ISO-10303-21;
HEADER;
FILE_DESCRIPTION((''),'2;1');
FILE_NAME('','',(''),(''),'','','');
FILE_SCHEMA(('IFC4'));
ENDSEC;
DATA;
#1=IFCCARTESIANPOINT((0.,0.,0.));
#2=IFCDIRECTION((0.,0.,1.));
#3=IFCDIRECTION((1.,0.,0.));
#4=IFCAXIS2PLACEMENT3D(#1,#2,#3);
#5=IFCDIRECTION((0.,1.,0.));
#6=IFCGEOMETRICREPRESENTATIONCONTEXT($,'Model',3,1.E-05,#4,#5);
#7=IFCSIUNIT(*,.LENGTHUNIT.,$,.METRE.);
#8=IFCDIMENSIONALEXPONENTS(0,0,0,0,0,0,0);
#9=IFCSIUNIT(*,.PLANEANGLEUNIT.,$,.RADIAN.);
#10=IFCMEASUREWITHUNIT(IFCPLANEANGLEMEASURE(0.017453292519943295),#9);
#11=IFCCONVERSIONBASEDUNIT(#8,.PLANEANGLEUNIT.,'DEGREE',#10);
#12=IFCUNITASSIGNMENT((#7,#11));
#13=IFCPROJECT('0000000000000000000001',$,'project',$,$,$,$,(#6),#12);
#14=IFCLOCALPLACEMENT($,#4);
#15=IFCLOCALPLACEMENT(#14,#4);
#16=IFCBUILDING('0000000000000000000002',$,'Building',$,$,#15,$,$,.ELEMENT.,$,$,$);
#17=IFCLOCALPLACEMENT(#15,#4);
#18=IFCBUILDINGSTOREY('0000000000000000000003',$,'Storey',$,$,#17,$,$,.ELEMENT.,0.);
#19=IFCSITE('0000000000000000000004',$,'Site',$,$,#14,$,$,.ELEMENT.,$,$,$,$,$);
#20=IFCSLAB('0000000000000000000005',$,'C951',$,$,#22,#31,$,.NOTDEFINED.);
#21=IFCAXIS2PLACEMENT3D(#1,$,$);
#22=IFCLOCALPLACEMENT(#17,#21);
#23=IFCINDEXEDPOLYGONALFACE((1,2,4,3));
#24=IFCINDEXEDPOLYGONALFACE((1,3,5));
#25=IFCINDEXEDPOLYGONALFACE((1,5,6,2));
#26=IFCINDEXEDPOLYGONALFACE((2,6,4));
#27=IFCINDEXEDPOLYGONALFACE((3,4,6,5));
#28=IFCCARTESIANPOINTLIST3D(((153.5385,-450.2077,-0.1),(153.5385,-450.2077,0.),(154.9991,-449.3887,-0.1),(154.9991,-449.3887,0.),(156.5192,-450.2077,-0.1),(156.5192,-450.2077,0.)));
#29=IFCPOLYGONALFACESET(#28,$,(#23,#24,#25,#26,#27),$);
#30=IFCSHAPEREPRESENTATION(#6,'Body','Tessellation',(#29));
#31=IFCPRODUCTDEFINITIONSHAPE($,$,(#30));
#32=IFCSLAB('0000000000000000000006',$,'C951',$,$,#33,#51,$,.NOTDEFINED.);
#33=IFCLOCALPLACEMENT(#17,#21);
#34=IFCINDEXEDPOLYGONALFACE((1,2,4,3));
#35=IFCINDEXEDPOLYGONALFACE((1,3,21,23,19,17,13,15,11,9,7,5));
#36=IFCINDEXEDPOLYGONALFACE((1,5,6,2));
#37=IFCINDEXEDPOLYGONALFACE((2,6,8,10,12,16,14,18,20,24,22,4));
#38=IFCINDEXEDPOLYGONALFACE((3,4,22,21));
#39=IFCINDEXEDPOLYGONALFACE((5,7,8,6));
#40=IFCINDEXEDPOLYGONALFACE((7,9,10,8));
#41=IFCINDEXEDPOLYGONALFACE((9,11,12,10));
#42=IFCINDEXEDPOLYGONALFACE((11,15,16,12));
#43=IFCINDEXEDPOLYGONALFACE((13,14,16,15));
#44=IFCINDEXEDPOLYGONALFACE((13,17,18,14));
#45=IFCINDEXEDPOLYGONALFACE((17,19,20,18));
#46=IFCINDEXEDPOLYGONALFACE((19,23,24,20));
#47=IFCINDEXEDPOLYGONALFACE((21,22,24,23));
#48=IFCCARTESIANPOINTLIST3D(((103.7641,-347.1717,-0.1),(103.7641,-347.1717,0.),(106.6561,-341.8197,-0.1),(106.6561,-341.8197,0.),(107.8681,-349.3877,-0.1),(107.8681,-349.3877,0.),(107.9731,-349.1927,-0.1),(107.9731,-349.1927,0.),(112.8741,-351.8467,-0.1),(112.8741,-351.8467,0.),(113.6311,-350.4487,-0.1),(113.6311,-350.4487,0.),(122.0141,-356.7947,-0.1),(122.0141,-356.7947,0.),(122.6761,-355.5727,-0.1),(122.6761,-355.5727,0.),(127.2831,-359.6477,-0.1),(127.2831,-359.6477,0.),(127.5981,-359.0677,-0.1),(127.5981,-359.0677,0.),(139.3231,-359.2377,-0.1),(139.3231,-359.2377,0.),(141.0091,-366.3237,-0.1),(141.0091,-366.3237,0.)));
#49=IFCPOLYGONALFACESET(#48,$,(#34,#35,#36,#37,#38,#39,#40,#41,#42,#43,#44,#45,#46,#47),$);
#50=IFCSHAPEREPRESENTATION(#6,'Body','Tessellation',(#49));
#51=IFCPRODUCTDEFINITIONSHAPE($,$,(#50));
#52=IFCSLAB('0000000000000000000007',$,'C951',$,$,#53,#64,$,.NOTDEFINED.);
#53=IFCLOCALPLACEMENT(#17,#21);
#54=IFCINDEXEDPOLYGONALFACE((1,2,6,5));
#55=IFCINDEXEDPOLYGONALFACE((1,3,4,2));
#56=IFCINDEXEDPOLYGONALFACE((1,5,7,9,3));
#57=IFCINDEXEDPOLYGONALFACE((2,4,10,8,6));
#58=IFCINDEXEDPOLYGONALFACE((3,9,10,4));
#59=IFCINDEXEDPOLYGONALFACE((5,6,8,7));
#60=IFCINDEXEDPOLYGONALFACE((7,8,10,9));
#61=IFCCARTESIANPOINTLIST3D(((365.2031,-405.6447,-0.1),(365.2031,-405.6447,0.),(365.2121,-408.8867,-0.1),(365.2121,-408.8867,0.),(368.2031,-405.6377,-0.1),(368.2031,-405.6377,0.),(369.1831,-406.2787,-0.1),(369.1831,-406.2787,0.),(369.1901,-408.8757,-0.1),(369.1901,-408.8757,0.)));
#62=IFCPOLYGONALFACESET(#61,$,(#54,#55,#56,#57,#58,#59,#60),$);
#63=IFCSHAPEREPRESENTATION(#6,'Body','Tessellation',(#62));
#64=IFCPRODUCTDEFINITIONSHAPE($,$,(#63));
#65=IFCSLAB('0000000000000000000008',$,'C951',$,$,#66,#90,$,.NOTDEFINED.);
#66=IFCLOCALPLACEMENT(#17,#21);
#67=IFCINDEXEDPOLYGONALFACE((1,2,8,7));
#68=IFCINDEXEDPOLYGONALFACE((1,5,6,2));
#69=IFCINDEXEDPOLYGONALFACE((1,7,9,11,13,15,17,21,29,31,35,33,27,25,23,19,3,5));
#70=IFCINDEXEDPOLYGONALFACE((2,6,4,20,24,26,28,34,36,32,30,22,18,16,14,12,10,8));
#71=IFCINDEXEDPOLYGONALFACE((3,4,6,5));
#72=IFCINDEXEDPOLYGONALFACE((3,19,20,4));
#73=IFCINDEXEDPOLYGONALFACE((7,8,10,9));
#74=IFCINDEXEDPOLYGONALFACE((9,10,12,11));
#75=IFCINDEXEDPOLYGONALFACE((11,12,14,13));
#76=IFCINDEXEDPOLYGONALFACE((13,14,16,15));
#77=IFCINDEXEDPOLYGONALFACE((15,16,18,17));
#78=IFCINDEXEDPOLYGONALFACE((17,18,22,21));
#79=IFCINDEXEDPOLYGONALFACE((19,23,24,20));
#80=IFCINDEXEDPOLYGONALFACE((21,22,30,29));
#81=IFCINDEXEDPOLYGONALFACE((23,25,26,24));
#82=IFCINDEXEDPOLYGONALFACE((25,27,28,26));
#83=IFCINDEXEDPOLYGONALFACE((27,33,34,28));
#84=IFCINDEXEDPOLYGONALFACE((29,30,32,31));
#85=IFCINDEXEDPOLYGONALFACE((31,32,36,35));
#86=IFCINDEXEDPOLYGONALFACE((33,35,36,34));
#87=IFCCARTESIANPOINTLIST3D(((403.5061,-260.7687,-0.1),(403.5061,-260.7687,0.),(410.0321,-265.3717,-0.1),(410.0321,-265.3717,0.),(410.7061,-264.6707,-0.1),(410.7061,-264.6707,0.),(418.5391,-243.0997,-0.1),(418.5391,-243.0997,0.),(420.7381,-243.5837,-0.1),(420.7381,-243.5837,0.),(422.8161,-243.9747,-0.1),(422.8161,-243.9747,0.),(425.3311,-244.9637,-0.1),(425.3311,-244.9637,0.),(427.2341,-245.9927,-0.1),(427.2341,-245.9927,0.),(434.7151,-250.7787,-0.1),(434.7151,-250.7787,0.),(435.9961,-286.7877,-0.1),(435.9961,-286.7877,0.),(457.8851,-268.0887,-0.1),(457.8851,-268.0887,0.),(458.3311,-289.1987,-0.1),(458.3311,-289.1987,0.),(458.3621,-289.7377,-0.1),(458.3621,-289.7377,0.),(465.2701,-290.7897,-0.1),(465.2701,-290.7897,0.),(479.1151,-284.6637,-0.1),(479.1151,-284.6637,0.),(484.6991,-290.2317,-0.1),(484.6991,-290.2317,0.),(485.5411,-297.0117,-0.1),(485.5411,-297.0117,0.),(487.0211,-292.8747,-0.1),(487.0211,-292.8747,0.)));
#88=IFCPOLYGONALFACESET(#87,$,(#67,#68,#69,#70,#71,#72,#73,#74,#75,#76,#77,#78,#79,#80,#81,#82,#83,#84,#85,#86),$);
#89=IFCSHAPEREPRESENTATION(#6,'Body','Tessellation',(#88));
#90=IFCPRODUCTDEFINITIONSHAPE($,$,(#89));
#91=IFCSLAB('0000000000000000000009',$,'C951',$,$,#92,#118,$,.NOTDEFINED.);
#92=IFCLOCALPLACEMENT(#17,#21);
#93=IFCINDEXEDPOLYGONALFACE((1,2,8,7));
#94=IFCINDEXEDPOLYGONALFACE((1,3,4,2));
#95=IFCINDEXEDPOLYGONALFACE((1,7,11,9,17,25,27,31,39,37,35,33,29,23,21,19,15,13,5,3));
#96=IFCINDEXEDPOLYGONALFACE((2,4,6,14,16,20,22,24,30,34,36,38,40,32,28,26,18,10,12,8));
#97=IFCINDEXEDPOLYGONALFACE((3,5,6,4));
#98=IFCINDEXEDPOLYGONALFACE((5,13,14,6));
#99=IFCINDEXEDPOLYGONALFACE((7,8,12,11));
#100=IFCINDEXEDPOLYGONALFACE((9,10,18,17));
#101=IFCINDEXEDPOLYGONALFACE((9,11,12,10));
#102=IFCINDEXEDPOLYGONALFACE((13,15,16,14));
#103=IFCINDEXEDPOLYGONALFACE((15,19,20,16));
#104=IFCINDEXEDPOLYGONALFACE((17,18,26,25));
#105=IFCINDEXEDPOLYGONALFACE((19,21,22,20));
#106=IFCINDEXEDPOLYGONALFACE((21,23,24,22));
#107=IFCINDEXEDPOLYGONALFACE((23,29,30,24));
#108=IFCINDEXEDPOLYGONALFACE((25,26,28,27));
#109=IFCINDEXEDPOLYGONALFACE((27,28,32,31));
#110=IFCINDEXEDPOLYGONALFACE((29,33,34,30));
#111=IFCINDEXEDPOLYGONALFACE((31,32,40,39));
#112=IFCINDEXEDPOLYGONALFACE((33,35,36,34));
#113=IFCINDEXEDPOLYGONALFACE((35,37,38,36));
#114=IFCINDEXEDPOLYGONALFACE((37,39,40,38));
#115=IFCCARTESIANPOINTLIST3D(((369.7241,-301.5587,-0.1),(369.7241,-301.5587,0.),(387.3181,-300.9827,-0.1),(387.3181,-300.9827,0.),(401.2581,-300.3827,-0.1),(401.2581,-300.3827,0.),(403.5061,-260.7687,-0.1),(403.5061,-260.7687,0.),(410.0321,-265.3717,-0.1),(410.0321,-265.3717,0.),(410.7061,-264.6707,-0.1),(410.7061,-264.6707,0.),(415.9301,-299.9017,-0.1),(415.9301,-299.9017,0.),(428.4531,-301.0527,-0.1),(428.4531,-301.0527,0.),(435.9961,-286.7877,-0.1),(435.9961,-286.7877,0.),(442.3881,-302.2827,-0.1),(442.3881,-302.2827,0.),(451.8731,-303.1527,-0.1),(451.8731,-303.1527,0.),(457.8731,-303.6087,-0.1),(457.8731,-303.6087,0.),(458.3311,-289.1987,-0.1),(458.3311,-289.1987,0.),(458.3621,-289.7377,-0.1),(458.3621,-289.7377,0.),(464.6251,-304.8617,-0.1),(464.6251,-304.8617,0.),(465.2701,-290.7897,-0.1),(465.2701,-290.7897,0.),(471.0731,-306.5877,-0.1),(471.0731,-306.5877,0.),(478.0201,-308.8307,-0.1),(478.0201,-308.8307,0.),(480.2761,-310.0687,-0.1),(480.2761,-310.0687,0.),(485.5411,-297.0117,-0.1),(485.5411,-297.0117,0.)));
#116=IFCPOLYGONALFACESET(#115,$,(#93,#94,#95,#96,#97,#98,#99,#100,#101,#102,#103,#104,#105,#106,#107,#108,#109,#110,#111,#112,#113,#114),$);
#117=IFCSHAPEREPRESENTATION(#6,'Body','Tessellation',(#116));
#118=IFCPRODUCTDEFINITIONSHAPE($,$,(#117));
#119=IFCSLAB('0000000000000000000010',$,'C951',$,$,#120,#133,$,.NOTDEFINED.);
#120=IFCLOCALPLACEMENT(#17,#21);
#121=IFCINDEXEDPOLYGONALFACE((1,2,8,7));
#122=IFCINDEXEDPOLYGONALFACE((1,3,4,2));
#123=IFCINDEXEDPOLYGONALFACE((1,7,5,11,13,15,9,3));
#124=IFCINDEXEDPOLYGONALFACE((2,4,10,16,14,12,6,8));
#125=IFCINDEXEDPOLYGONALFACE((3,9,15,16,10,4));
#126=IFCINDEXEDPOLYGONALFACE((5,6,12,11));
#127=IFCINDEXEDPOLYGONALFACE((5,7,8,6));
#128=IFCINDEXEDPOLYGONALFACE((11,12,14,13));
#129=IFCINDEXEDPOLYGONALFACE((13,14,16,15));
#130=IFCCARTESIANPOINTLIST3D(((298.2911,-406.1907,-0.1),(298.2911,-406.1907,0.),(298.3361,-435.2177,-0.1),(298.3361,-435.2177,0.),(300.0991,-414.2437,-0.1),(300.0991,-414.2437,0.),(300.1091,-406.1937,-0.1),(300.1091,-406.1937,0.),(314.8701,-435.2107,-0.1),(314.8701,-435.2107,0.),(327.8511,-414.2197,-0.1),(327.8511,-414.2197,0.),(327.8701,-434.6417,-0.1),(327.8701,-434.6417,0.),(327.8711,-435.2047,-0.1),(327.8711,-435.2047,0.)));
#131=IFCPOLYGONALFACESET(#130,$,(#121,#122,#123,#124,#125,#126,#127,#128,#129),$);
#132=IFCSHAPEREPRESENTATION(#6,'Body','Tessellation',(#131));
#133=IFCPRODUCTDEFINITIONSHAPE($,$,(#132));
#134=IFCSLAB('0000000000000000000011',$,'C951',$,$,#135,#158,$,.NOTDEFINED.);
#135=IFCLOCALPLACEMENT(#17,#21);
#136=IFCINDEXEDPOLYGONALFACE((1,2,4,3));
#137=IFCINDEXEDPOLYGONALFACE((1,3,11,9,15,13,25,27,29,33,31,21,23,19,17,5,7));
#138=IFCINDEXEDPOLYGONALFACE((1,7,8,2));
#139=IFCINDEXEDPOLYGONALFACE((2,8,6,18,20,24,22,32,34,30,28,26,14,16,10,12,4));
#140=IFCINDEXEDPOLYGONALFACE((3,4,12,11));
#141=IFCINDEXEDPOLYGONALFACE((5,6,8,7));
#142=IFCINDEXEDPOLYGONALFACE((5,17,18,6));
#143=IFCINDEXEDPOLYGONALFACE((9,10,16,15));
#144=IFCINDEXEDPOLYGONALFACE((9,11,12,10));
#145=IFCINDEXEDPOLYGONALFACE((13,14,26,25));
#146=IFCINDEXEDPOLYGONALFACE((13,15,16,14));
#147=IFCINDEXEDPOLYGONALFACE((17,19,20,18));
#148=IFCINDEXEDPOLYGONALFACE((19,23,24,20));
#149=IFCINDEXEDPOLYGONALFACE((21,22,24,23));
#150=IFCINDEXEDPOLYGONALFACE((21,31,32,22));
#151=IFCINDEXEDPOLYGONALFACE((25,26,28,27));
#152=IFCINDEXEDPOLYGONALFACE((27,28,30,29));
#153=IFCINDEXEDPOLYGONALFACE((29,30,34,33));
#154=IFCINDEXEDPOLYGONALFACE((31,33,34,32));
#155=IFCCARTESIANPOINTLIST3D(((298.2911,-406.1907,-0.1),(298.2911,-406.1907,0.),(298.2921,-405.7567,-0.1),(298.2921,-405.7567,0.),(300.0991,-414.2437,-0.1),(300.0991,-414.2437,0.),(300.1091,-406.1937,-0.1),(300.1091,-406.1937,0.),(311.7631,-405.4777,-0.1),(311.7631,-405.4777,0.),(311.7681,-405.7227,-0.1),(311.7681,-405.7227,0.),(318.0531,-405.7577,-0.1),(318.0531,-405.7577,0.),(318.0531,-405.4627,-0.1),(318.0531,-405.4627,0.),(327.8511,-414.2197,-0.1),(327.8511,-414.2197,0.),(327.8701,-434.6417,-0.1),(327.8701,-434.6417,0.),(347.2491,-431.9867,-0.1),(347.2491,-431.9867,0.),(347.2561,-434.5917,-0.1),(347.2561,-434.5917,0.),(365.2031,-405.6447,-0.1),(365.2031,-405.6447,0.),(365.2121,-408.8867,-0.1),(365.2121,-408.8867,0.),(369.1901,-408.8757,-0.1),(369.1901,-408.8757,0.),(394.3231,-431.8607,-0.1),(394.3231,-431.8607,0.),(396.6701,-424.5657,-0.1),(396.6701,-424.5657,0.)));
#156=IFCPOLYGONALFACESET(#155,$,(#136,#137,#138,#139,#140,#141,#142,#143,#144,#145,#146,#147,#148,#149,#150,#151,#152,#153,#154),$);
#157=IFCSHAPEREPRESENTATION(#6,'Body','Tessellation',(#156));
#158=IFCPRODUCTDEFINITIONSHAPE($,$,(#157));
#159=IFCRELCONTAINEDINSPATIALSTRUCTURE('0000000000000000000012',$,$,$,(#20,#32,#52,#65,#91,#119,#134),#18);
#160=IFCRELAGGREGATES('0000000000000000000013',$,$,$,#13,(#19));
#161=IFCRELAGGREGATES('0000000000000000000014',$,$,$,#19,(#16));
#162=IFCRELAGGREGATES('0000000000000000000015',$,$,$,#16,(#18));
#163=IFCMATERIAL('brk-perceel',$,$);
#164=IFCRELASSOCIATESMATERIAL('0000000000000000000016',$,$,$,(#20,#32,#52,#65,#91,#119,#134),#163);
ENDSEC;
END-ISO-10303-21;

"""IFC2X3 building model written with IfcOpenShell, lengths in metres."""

from ifc_helpers import new_model, entity, si_unit, converted_unit, direction, frame, origin_with_axes, place, context, project, spatial, polyline, outline, extrude, material, element, save


model = new_model("IFC2X3")

# Units and contexts
model_context = context("Model", 3, precision=1e-05, world=origin_with_axes(), true_north=direction((0.0, 1.0, 0.0)))
ifc_project = project(units=[si_unit("LENGTHUNIT", "METRE"), converted_unit("PLANEANGLEUNIT", "DEGREE", entity("IfcPlaneAngleMeasure", 0.017453292519943295), si_unit("PLANEANGLEUNIT", "RADIAN"), dimensions=[0, 0, 0, 0, 0, 0, 0])], contexts=[model_context])

# Site, building, storey
site_placement = place(None, origin_with_axes())
site = spatial("IfcSite", under=ifc_project, at=site_placement, Name="Site", CompositionType="ELEMENT")
building_placement = place(site_placement, origin_with_axes())
building = spatial("IfcBuilding", under=site, at=building_placement, Name="Building", CompositionType="ELEMENT")
storey_placement = place(building_placement, origin_with_axes())
storey = spatial("IfcBuildingStorey", under=building, at=storey_placement, Name="Storey", CompositionType="ELEMENT", Elevation=0.0)

# Slabs
ifc_material = material(Name="brk-perceel")
slab_1_placement = place(storey_placement, frame((0.0, 0.0, -0.1), z_axis=(0.0, 0.0, 1.0), x_axis=(1.0, 0.0, 0.0)))
element("IfcSlab", 1, at=slab_1_placement, inside=storey, material=ifc_material, Name="C951", PredefinedType="NOTDEFINED", context=model_context, shape_type="SweptSolid", body=[
    extrude(outline(polyline([(154.9991, -449.3887), (156.5192, -450.2077), (153.5385, -450.2077), (154.9991, -449.3887)])), origin_with_axes(), (0.0, 0.0, 1.0), 0.1),
])
slab_2_placement = place(storey_placement, frame((0.0, 0.0, -0.1), z_axis=(0.0, 0.0, 1.0), x_axis=(1.0, 0.0, 0.0)))
element("IfcSlab", 2, at=slab_2_placement, inside=storey, material=ifc_material, Name="C951", PredefinedType="NOTDEFINED", context=model_context, shape_type="SweptSolid", body=[
    extrude(outline(polyline([(106.6561, -341.8197), (139.3231, -359.2377), (141.0091, -366.3237), (127.5981, -359.0677), (127.2831, -359.6477), (122.0141, -356.7947), (122.6761, -355.5727), (113.6311, -350.4487), (112.8741, -351.8467), (107.9731, -349.1927), (107.8681, -349.3877), (103.7641, -347.1717), (106.6561, -341.8197)])), origin_with_axes(), (0.0, 0.0, 1.0), 0.1),
])
slab_3_placement = place(storey_placement, frame((0.0, 0.0, -0.1), z_axis=(0.0, 0.0, 1.0), x_axis=(1.0, 0.0, 0.0)))
element("IfcSlab", 3, at=slab_3_placement, inside=storey, material=ifc_material, Name="C951", PredefinedType="NOTDEFINED", context=model_context, shape_type="SweptSolid", body=[
    extrude(outline(polyline([(368.2031, -405.6377), (369.1831, -406.2787), (369.1901, -408.8757), (365.2121, -408.8867), (365.2031, -405.6447), (368.2031, -405.6377)])), origin_with_axes(), (0.0, 0.0, 1.0), 0.1),
])
slab_4_placement = place(storey_placement, frame((0.0, 0.0, -0.1), z_axis=(0.0, 0.0, 1.0), x_axis=(1.0, 0.0, 0.0)))
element("IfcSlab", 4, at=slab_4_placement, inside=storey, material=ifc_material, Name="C951", PredefinedType="NOTDEFINED", context=model_context, shape_type="SweptSolid", body=[
    extrude(outline(polyline([(465.2701, -290.7897), (458.3621, -289.7377), (458.3311, -289.1987), (435.9961, -286.7877), (410.0321, -265.3717), (410.7061, -264.6707), (403.5061, -260.7687), (418.5391, -243.0997), (420.7381, -243.5837), (422.8161, -243.9747), (425.3311, -244.9637), (427.2341, -245.9927), (434.7151, -250.7787), (457.8851, -268.0887), (479.1151, -284.6637), (484.6991, -290.2317), (487.0211, -292.8747), (485.5411, -297.0117), (465.2701, -290.7897)])), origin_with_axes(), (0.0, 0.0, 1.0), 0.1),
])
slab_5_placement = place(storey_placement, frame((0.0, 0.0, -0.1), z_axis=(0.0, 0.0, 1.0), x_axis=(1.0, 0.0, 0.0)))
element("IfcSlab", 5, at=slab_5_placement, inside=storey, material=ifc_material, Name="C951", PredefinedType="NOTDEFINED", context=model_context, shape_type="SweptSolid", body=[
    extrude(outline(polyline([(478.0201, -308.8307), (471.0731, -306.5877), (464.6251, -304.8617), (457.8731, -303.6087), (451.8731, -303.1527), (442.3881, -302.2827), (428.4531, -301.0527), (415.9301, -299.9017), (401.2581, -300.3827), (387.3181, -300.9827), (369.7241, -301.5587), (403.5061, -260.7687), (410.7061, -264.6707), (410.0321, -265.3717), (435.9961, -286.7877), (458.3311, -289.1987), (458.3621, -289.7377), (465.2701, -290.7897), (485.5411, -297.0117), (480.2761, -310.0687), (478.0201, -308.8307)])), origin_with_axes(), (0.0, 0.0, 1.0), 0.1),
])
slab_6_placement = place(storey_placement, frame((0.0, 0.0, -0.1), z_axis=(0.0, 0.0, 1.0), x_axis=(1.0, 0.0, 0.0)))
element("IfcSlab", 6, at=slab_6_placement, inside=storey, material=ifc_material, Name="C951", PredefinedType="NOTDEFINED", context=model_context, shape_type="SweptSolid", body=[
    extrude(outline(polyline([(327.8711, -435.2047), (314.8701, -435.2107), (298.3361, -435.2177), (298.2911, -406.1907), (300.1091, -406.1937), (300.0991, -414.2437), (327.8511, -414.2197), (327.8701, -434.6417), (327.8711, -435.2047)])), origin_with_axes(), (0.0, 0.0, 1.0), 0.1),
])
slab_7_placement = place(storey_placement, frame((0.0, 0.0, -0.1), z_axis=(0.0, 0.0, 1.0), x_axis=(1.0, 0.0, 0.0)))
element("IfcSlab", 7, at=slab_7_placement, inside=storey, material=ifc_material, Name="C951", PredefinedType="NOTDEFINED", context=model_context, shape_type="SweptSolid", body=[
    extrude(outline(polyline([(298.2921, -405.7567), (311.7681, -405.7227), (311.7631, -405.4777), (318.0531, -405.4627), (318.0531, -405.7577), (365.2031, -405.6447), (365.2121, -408.8867), (369.1901, -408.8757), (396.6701, -424.5657), (394.3231, -431.8607), (347.2491, -431.9867), (347.2561, -434.5917), (327.8701, -434.6417), (327.8511, -414.2197), (300.0991, -414.2437), (300.1091, -406.1937), (298.2911, -406.1907), (298.2921, -405.7567)])), origin_with_axes(), (0.0, 0.0, 1.0), 0.1),
])

save(model, "model.ifc")
